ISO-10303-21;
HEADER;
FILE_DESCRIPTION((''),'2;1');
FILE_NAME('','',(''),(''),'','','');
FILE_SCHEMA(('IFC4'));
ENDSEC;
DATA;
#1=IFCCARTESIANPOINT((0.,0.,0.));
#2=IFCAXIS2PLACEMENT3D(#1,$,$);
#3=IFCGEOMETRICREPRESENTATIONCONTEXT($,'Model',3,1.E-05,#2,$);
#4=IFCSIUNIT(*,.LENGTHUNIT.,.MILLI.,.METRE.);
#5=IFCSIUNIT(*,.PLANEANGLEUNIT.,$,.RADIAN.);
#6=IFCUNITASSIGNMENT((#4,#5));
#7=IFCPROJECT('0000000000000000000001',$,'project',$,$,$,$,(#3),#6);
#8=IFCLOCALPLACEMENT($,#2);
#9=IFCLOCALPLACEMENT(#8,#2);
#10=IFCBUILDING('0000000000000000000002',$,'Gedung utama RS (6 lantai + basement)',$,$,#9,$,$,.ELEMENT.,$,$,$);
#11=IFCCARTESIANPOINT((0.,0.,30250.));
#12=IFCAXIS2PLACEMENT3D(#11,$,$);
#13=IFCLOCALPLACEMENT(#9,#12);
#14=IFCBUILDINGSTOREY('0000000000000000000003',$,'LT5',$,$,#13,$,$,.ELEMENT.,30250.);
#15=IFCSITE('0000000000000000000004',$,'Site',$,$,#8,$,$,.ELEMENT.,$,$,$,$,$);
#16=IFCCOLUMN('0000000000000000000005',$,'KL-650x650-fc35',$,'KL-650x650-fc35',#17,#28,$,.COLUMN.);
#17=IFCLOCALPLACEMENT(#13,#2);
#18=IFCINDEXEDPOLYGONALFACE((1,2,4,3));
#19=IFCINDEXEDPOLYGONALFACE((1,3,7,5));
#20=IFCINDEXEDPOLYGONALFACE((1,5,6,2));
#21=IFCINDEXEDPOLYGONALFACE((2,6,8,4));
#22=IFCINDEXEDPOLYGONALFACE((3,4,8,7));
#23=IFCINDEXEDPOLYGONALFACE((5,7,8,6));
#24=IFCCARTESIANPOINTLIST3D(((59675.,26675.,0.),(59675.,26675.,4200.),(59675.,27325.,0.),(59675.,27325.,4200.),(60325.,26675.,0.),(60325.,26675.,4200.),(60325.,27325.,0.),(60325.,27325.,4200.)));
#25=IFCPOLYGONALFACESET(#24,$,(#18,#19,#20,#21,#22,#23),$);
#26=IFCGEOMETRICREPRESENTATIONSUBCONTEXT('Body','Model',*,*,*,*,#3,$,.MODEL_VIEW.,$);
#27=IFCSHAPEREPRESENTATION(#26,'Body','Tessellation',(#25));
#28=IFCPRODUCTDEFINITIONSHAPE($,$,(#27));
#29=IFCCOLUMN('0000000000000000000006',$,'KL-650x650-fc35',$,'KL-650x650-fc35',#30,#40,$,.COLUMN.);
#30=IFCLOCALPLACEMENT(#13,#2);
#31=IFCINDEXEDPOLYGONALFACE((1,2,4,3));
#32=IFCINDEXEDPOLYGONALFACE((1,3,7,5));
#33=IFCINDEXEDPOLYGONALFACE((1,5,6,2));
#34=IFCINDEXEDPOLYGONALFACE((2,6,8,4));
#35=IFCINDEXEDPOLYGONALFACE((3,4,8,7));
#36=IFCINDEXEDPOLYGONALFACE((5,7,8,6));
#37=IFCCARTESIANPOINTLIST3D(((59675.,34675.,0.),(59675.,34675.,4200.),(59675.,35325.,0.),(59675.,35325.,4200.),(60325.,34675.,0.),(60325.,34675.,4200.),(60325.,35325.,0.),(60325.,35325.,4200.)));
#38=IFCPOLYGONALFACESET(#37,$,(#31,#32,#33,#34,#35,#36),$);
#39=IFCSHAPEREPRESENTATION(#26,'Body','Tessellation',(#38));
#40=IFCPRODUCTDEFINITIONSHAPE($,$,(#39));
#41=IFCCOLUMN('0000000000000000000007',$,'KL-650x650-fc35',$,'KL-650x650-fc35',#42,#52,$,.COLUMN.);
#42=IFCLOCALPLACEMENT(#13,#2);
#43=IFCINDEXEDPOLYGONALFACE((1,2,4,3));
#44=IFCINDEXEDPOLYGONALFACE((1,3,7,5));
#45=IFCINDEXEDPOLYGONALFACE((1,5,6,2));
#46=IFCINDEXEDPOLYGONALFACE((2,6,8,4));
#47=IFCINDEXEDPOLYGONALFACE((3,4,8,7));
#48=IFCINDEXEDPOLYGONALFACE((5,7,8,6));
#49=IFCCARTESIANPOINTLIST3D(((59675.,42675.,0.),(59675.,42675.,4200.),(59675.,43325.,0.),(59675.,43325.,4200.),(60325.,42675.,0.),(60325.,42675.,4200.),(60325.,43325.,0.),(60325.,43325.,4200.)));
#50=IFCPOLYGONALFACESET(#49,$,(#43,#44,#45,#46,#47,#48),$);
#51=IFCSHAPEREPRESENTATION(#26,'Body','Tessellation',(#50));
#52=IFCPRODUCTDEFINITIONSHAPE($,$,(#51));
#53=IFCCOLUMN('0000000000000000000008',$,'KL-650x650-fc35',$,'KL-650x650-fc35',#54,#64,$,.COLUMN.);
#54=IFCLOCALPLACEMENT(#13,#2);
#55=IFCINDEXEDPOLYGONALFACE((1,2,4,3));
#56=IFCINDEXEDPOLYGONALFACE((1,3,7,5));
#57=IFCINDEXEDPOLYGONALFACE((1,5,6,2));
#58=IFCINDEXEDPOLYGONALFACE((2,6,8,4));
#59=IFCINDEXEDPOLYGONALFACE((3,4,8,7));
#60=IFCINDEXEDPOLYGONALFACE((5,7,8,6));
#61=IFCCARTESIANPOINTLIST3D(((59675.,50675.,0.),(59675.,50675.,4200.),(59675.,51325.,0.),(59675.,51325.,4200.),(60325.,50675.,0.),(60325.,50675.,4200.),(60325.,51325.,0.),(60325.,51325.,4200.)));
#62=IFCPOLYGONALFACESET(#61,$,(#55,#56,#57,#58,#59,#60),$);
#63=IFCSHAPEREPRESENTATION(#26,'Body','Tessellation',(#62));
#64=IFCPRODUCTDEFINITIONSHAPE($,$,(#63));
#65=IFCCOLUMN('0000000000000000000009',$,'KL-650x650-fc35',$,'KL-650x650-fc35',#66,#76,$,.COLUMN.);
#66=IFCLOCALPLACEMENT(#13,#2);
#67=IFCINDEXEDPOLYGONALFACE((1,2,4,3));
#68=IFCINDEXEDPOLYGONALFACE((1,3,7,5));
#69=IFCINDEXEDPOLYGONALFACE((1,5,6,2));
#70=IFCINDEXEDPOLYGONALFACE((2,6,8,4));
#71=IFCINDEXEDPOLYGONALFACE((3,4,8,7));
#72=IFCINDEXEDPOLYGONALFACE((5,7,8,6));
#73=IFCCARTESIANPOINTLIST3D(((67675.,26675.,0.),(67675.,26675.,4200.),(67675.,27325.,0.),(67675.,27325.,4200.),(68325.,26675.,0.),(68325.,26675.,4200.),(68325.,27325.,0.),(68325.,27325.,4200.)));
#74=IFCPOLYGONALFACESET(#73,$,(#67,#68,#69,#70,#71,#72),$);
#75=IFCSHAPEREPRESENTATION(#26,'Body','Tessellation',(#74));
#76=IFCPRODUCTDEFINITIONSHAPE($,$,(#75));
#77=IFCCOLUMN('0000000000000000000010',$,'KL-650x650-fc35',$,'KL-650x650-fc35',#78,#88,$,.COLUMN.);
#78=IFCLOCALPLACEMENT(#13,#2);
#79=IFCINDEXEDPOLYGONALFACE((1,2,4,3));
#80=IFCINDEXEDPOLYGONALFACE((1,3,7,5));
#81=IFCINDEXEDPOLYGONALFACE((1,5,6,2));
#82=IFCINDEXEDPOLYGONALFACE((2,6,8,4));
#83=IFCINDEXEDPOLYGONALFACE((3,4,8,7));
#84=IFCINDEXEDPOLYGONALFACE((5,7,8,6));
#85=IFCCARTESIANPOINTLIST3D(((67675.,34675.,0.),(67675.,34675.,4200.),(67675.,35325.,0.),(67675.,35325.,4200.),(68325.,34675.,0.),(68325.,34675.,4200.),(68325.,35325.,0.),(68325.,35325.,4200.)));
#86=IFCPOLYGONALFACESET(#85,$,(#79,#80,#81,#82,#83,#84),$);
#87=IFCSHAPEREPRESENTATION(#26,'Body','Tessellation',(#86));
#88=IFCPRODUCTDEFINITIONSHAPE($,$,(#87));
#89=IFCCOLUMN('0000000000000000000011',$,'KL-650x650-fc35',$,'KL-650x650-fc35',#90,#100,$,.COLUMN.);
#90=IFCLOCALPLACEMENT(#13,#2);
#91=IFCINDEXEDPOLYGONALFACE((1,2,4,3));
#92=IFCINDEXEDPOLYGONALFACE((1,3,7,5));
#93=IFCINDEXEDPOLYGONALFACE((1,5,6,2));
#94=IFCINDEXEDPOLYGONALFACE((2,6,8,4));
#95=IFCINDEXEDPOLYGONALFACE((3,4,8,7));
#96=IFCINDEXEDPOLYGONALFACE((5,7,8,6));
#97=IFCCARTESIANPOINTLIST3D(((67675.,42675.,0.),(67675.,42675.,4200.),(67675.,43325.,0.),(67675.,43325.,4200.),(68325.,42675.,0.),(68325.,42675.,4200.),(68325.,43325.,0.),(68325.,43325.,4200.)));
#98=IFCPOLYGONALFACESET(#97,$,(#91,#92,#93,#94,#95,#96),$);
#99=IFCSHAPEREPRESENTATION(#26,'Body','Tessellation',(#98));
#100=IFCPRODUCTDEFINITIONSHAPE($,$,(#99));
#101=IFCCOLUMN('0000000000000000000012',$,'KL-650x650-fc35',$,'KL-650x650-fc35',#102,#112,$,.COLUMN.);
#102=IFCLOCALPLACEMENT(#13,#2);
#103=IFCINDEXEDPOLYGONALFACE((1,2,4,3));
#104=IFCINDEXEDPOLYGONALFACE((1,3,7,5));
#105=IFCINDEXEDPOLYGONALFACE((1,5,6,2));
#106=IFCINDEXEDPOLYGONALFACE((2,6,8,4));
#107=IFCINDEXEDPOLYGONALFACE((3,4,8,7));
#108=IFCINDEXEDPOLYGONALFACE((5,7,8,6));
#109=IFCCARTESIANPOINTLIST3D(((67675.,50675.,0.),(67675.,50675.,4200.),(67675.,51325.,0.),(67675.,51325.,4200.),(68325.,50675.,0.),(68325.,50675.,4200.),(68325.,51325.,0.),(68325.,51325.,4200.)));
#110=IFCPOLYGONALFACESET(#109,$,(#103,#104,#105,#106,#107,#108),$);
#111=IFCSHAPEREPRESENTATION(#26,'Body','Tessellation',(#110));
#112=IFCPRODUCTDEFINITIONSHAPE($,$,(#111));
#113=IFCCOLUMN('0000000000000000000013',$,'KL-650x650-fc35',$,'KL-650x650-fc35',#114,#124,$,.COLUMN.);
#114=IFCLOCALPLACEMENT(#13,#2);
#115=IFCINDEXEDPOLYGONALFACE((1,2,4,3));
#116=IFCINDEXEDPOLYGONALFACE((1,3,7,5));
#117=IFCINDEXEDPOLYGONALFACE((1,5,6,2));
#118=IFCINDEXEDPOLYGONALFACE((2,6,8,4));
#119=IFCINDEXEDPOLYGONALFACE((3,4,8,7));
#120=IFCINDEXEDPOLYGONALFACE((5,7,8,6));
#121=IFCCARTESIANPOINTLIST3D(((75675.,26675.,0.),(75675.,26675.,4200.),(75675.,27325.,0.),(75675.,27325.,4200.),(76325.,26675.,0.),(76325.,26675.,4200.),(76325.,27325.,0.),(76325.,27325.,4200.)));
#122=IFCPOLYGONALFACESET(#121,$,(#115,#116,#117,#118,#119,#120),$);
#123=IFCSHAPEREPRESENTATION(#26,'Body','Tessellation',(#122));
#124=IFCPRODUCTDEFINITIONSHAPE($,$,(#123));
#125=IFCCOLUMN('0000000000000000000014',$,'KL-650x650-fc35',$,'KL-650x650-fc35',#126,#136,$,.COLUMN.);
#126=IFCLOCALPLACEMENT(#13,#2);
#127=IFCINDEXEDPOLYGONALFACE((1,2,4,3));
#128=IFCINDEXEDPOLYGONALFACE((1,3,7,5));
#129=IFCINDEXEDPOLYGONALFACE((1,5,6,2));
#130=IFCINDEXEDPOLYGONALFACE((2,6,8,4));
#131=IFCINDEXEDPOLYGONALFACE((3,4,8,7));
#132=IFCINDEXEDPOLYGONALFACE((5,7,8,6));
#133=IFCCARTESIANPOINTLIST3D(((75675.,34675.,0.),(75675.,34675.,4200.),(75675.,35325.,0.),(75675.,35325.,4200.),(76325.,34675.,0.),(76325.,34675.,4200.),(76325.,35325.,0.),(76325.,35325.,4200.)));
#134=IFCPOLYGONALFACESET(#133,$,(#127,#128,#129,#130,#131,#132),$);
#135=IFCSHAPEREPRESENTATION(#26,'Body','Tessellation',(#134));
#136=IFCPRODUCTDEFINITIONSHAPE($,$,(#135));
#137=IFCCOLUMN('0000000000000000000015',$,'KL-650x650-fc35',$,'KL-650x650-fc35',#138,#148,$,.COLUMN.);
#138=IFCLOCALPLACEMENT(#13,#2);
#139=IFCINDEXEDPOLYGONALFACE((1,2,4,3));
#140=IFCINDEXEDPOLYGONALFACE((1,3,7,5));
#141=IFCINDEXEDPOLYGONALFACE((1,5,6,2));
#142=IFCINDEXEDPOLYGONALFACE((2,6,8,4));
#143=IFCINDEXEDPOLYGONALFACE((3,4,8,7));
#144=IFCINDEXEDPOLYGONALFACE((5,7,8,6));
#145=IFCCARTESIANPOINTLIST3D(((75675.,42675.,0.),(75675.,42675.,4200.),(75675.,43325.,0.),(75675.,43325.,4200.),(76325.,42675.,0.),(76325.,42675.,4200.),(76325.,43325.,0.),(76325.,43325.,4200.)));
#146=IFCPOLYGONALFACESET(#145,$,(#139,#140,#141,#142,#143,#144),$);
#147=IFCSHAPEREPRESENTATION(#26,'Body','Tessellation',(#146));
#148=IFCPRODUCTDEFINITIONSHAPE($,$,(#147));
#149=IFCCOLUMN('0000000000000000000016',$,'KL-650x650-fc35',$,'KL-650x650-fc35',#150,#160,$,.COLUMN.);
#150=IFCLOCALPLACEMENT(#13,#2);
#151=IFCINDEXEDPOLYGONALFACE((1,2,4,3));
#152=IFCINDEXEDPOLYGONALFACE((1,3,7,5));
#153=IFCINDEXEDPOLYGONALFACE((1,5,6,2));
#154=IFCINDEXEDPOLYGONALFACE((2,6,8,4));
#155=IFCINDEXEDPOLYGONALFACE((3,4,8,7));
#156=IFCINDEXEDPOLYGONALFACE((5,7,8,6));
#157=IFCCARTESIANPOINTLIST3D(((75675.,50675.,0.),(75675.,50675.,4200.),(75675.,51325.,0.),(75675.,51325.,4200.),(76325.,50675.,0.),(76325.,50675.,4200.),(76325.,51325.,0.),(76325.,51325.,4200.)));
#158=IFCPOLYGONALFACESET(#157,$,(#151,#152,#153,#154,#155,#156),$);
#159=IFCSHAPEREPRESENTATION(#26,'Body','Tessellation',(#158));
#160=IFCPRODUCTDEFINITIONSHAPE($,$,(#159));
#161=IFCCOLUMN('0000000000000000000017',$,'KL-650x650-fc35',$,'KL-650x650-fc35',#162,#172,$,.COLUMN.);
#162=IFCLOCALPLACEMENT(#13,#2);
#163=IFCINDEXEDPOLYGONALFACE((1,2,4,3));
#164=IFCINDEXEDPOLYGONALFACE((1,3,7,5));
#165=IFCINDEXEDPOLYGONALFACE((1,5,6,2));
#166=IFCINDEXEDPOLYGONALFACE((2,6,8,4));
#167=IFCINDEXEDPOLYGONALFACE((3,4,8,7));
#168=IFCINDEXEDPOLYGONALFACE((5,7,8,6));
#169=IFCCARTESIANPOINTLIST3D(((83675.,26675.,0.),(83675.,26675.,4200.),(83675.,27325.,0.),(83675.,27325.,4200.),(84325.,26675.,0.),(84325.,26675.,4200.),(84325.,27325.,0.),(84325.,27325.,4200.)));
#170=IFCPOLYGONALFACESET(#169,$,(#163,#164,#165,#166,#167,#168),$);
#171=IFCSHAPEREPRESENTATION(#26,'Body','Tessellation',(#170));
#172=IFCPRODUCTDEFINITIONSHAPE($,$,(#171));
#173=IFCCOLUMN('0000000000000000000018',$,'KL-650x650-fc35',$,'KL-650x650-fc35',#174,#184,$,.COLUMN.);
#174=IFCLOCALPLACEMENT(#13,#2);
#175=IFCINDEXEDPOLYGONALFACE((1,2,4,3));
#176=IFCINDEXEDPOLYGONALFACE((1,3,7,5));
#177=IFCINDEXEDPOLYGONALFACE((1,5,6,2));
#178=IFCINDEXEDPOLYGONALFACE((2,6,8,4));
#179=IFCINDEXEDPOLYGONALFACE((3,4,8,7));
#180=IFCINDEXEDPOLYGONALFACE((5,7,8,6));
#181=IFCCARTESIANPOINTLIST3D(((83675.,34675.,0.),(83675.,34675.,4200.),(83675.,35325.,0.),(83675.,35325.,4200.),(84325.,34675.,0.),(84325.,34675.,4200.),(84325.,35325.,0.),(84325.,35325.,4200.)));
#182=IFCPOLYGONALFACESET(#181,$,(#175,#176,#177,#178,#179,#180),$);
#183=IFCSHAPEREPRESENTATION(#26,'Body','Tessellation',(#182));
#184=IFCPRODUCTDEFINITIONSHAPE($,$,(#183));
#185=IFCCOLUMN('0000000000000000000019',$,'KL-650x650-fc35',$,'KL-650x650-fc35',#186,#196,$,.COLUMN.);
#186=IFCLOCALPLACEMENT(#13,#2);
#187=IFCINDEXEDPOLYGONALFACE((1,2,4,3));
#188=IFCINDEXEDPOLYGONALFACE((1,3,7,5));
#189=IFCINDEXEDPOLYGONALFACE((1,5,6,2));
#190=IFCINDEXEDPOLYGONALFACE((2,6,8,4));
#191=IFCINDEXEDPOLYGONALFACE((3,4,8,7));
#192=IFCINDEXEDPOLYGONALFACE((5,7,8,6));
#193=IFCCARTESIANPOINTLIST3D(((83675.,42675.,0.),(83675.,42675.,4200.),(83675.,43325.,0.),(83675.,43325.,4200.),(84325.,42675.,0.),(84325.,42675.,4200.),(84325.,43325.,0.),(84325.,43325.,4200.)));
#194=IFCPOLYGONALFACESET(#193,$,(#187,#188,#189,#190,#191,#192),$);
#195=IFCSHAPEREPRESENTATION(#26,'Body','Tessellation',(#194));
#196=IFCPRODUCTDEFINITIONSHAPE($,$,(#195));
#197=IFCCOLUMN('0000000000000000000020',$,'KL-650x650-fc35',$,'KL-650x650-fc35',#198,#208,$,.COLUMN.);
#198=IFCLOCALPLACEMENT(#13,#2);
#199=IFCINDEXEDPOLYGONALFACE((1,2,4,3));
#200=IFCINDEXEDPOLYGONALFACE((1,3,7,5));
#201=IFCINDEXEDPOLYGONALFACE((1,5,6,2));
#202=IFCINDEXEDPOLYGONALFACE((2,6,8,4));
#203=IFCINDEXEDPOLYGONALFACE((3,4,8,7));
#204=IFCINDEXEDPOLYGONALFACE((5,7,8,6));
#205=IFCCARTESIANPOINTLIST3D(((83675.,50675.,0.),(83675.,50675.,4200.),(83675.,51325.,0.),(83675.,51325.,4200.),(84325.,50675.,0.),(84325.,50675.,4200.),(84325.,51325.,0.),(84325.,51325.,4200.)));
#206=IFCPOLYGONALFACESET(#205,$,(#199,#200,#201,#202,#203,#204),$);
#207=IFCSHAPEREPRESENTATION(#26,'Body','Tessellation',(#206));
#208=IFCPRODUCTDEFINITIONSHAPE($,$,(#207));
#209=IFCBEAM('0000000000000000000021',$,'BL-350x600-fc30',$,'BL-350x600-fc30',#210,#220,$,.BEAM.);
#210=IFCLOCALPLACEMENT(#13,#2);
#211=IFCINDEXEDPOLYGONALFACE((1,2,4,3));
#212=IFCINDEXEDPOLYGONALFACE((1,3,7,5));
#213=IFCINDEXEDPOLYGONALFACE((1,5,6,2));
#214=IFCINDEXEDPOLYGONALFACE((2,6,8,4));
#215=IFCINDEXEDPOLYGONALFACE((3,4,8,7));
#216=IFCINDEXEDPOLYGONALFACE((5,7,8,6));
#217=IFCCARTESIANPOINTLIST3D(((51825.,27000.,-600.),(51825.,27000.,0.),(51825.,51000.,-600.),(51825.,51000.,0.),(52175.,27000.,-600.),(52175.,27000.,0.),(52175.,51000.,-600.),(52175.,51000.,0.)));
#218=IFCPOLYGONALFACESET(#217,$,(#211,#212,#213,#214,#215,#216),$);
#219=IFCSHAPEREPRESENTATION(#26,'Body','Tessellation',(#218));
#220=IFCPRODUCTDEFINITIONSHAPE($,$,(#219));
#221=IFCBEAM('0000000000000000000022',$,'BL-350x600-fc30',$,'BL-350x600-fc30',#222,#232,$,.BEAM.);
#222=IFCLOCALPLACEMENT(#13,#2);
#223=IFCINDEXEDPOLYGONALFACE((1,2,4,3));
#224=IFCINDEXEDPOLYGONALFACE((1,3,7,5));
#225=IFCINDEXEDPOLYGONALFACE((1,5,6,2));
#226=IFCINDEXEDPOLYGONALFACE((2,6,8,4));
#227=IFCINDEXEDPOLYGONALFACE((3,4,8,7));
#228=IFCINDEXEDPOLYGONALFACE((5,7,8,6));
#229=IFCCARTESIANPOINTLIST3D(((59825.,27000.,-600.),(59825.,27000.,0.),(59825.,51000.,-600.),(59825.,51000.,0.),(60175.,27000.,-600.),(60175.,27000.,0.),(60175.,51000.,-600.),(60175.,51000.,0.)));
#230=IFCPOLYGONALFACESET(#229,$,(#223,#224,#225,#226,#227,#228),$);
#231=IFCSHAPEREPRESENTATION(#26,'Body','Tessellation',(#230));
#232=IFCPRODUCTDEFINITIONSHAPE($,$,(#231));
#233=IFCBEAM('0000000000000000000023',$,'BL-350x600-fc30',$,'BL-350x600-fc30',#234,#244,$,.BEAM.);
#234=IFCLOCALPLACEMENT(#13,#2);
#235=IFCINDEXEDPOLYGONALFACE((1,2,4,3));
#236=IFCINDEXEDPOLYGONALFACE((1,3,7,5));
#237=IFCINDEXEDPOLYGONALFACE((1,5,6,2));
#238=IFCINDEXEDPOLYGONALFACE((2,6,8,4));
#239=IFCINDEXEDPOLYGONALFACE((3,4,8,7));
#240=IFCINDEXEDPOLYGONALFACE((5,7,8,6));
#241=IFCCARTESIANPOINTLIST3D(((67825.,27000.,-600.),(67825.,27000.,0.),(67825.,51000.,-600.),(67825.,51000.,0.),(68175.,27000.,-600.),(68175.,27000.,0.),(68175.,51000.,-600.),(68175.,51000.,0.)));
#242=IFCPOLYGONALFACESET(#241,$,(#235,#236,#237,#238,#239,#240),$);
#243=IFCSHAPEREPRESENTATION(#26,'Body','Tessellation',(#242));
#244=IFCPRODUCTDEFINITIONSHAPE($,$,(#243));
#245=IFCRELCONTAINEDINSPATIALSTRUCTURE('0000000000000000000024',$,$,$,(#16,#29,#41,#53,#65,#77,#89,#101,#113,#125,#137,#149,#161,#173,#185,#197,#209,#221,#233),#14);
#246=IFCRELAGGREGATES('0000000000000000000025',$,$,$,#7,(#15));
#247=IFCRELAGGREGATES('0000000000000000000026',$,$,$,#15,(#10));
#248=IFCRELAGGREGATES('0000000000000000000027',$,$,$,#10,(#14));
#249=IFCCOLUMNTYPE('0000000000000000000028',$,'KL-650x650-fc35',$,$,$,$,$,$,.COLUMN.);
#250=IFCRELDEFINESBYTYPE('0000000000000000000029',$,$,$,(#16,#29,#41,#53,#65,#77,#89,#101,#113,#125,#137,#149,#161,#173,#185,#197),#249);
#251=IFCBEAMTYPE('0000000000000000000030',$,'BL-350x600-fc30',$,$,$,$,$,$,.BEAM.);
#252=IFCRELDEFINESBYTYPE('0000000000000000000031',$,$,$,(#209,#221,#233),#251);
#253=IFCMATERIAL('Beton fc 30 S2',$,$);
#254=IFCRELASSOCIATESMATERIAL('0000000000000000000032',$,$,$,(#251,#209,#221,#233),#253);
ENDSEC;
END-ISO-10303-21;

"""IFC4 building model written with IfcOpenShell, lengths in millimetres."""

from ifc_helpers import new_model, si_unit, frame, origin, origin_2d, place, context, subcontext, project, spatial, rectangle, extrude, material, material_profile, profile_set, profile_usage, type_object, element, save


model = new_model("IFC4")

# Units and contexts
model_context = context("Model", 3, precision=1e-05, world=origin())
body_context = subcontext(model_context, "Body", "Model", "MODEL_VIEW")
ifc_project = project(units=[si_unit("LENGTHUNIT", "METRE", prefix="MILLI"), si_unit("PLANEANGLEUNIT", "RADIAN")], contexts=[model_context])

# Site, building, storey
site_placement = place(None, origin())
site = spatial("IfcSite", under=ifc_project, at=site_placement, Name="Site", CompositionType="ELEMENT")
building_placement = place(site_placement, origin())
building = spatial("IfcBuilding", under=site, at=building_placement, Name="Gedung utama RS (6 lantai + basement)", CompositionType="ELEMENT")
storey_placement = place(building_placement, frame((0.0, 0.0, 30250.0)))
storey = spatial("IfcBuildingStorey", under=building, at=storey_placement, Name="LT5", CompositionType="ELEMENT", Elevation=30250.0)

# Columns
ifc_material_profile_1 = material_profile(None, rectangle(XDim=650.0, YDim=650.0, at=origin_2d()), Name="KL-650x650-fc35")
ifc_profile_set_1 = profile_set([ifc_material_profile_1], Name="KL-650x650-fc35")
ifc_profile_usage_1 = profile_usage(ifc_profile_set_1, cardinal=5)
column_type = type_object("IfcColumnType", Name="KL-650x650-fc35", PredefinedType="COLUMN", material=ifc_profile_set_1)
for number, where, z_axis, x_axis, name in (
    (1, (60000.0, 27000.0, 0.0), (0.0, 0.0, 1.0), (1.0, 0.0, 0.0), "KL-650x650-fc35"),
    (2, (60000.0, 35000.0, 0.0), (0.0, 0.0, 1.0), (1.0, 0.0, 0.0), "KL-650x650-fc35"),
    (3, (60000.0, 43000.0, 0.0), (0.0, 0.0, 1.0), (1.0, 0.0, 0.0), "KL-650x650-fc35"),
    (4, (60000.0, 51000.0, 0.0), (0.0, 0.0, 1.0), (1.0, 0.0, 0.0), "KL-650x650-fc35"),
    (5, (68000.0, 27000.0, 0.0), (0.0, 0.0, 1.0), (1.0, 0.0, 0.0), "KL-650x650-fc35"),
    (6, (68000.0, 35000.0, 0.0), (0.0, 0.0, 1.0), (1.0, 0.0, 0.0), "KL-650x650-fc35"),
    (7, (68000.0, 43000.0, 0.0), (0.0, 0.0, 1.0), (1.0, 0.0, 0.0), "KL-650x650-fc35"),
    (8, (68000.0, 51000.0, 0.0), (0.0, 0.0, 1.0), (1.0, 0.0, 0.0), "KL-650x650-fc35"),
    (9, (76000.0, 27000.0, 0.0), (0.0, 0.0, 1.0), (1.0, 0.0, 0.0), "KL-650x650-fc35"),
    (10, (76000.0, 35000.0, 0.0), (0.0, 0.0, 1.0), (1.0, 0.0, 0.0), "KL-650x650-fc35"),
    (11, (76000.0, 43000.0, 0.0), (0.0, 0.0, 1.0), (1.0, 0.0, 0.0), "KL-650x650-fc35"),
    (12, (76000.0, 51000.0, 0.0), (0.0, 0.0, 1.0), (1.0, 0.0, 0.0), "KL-650x650-fc35"),
    (13, (84000.0, 27000.0, 0.0), (0.0, 0.0, 1.0), (1.0, 0.0, 0.0), "KL-650x650-fc35"),
    (14, (84000.0, 35000.0, 0.0), (0.0, 0.0, 1.0), (1.0, 0.0, 0.0), "KL-650x650-fc35"),
    (15, (84000.0, 43000.0, 0.0), (0.0, 0.0, 1.0), (1.0, 0.0, 0.0), "KL-650x650-fc35"),
    (16, (84000.0, 51000.0, 0.0), (0.0, 0.0, 1.0), (1.0, 0.0, 0.0), "KL-650x650-fc35"),
):
    element("IfcColumn", number, at=place(storey_placement, frame(where, z_axis=z_axis, x_axis=x_axis)), inside=storey, type_object=column_type, material=ifc_profile_usage_1, Name=name, ObjectType="KL-650x650-fc35", PredefinedType="COLUMN", context=body_context, shape_type="SweptSolid", body=[
        extrude(rectangle(XDim=650.0, YDim=650.0, at=origin_2d()), origin(), (0.0, 0.0, 1.0), 4200.0),
    ])

# Beams
ifc_material = material(Name="Beton fc 30 S2")
ifc_material_profile_2 = material_profile(ifc_material, rectangle(XDim=350.0, YDim=600.0, at=origin_2d()), Name="BL-350x600-fc30")
ifc_profile_set_2 = profile_set([ifc_material_profile_2], Name="BL-350x600-fc30")
ifc_profile_usage_2 = profile_usage(ifc_profile_set_2, cardinal=8)
beam_type = type_object("IfcBeamType", Name="BL-350x600-fc30", PredefinedType="BEAM", material=ifc_profile_set_2)
for number, where, name in (
    (17, (52000.0, 27000.0, -300.0), "BL-350x600-fc30"),
    (18, (60000.0, 27000.0, -300.0), "BL-350x600-fc30"),
    (19, (68000.0, 27000.0, -300.0), "BL-350x600-fc30"),
):
    element("IfcBeam", number, at=place(storey_placement, frame(where)), inside=storey, type_object=beam_type, material=ifc_profile_usage_2, Name=name, ObjectType="BL-350x600-fc30", PredefinedType="BEAM", context=body_context, shape_type="SweptSolid", body=[
        extrude(rectangle(XDim=350.0, YDim=600.0, at=origin_2d()), frame((0.0, 0.0, 0.0), z_axis=(0.0, 1.0, 0.0), x_axis=(-1.0, 0.0, 0.0)), (0.0, 0.0, 1.0), 24000.0),
    ])

save(model, "model.ifc")
